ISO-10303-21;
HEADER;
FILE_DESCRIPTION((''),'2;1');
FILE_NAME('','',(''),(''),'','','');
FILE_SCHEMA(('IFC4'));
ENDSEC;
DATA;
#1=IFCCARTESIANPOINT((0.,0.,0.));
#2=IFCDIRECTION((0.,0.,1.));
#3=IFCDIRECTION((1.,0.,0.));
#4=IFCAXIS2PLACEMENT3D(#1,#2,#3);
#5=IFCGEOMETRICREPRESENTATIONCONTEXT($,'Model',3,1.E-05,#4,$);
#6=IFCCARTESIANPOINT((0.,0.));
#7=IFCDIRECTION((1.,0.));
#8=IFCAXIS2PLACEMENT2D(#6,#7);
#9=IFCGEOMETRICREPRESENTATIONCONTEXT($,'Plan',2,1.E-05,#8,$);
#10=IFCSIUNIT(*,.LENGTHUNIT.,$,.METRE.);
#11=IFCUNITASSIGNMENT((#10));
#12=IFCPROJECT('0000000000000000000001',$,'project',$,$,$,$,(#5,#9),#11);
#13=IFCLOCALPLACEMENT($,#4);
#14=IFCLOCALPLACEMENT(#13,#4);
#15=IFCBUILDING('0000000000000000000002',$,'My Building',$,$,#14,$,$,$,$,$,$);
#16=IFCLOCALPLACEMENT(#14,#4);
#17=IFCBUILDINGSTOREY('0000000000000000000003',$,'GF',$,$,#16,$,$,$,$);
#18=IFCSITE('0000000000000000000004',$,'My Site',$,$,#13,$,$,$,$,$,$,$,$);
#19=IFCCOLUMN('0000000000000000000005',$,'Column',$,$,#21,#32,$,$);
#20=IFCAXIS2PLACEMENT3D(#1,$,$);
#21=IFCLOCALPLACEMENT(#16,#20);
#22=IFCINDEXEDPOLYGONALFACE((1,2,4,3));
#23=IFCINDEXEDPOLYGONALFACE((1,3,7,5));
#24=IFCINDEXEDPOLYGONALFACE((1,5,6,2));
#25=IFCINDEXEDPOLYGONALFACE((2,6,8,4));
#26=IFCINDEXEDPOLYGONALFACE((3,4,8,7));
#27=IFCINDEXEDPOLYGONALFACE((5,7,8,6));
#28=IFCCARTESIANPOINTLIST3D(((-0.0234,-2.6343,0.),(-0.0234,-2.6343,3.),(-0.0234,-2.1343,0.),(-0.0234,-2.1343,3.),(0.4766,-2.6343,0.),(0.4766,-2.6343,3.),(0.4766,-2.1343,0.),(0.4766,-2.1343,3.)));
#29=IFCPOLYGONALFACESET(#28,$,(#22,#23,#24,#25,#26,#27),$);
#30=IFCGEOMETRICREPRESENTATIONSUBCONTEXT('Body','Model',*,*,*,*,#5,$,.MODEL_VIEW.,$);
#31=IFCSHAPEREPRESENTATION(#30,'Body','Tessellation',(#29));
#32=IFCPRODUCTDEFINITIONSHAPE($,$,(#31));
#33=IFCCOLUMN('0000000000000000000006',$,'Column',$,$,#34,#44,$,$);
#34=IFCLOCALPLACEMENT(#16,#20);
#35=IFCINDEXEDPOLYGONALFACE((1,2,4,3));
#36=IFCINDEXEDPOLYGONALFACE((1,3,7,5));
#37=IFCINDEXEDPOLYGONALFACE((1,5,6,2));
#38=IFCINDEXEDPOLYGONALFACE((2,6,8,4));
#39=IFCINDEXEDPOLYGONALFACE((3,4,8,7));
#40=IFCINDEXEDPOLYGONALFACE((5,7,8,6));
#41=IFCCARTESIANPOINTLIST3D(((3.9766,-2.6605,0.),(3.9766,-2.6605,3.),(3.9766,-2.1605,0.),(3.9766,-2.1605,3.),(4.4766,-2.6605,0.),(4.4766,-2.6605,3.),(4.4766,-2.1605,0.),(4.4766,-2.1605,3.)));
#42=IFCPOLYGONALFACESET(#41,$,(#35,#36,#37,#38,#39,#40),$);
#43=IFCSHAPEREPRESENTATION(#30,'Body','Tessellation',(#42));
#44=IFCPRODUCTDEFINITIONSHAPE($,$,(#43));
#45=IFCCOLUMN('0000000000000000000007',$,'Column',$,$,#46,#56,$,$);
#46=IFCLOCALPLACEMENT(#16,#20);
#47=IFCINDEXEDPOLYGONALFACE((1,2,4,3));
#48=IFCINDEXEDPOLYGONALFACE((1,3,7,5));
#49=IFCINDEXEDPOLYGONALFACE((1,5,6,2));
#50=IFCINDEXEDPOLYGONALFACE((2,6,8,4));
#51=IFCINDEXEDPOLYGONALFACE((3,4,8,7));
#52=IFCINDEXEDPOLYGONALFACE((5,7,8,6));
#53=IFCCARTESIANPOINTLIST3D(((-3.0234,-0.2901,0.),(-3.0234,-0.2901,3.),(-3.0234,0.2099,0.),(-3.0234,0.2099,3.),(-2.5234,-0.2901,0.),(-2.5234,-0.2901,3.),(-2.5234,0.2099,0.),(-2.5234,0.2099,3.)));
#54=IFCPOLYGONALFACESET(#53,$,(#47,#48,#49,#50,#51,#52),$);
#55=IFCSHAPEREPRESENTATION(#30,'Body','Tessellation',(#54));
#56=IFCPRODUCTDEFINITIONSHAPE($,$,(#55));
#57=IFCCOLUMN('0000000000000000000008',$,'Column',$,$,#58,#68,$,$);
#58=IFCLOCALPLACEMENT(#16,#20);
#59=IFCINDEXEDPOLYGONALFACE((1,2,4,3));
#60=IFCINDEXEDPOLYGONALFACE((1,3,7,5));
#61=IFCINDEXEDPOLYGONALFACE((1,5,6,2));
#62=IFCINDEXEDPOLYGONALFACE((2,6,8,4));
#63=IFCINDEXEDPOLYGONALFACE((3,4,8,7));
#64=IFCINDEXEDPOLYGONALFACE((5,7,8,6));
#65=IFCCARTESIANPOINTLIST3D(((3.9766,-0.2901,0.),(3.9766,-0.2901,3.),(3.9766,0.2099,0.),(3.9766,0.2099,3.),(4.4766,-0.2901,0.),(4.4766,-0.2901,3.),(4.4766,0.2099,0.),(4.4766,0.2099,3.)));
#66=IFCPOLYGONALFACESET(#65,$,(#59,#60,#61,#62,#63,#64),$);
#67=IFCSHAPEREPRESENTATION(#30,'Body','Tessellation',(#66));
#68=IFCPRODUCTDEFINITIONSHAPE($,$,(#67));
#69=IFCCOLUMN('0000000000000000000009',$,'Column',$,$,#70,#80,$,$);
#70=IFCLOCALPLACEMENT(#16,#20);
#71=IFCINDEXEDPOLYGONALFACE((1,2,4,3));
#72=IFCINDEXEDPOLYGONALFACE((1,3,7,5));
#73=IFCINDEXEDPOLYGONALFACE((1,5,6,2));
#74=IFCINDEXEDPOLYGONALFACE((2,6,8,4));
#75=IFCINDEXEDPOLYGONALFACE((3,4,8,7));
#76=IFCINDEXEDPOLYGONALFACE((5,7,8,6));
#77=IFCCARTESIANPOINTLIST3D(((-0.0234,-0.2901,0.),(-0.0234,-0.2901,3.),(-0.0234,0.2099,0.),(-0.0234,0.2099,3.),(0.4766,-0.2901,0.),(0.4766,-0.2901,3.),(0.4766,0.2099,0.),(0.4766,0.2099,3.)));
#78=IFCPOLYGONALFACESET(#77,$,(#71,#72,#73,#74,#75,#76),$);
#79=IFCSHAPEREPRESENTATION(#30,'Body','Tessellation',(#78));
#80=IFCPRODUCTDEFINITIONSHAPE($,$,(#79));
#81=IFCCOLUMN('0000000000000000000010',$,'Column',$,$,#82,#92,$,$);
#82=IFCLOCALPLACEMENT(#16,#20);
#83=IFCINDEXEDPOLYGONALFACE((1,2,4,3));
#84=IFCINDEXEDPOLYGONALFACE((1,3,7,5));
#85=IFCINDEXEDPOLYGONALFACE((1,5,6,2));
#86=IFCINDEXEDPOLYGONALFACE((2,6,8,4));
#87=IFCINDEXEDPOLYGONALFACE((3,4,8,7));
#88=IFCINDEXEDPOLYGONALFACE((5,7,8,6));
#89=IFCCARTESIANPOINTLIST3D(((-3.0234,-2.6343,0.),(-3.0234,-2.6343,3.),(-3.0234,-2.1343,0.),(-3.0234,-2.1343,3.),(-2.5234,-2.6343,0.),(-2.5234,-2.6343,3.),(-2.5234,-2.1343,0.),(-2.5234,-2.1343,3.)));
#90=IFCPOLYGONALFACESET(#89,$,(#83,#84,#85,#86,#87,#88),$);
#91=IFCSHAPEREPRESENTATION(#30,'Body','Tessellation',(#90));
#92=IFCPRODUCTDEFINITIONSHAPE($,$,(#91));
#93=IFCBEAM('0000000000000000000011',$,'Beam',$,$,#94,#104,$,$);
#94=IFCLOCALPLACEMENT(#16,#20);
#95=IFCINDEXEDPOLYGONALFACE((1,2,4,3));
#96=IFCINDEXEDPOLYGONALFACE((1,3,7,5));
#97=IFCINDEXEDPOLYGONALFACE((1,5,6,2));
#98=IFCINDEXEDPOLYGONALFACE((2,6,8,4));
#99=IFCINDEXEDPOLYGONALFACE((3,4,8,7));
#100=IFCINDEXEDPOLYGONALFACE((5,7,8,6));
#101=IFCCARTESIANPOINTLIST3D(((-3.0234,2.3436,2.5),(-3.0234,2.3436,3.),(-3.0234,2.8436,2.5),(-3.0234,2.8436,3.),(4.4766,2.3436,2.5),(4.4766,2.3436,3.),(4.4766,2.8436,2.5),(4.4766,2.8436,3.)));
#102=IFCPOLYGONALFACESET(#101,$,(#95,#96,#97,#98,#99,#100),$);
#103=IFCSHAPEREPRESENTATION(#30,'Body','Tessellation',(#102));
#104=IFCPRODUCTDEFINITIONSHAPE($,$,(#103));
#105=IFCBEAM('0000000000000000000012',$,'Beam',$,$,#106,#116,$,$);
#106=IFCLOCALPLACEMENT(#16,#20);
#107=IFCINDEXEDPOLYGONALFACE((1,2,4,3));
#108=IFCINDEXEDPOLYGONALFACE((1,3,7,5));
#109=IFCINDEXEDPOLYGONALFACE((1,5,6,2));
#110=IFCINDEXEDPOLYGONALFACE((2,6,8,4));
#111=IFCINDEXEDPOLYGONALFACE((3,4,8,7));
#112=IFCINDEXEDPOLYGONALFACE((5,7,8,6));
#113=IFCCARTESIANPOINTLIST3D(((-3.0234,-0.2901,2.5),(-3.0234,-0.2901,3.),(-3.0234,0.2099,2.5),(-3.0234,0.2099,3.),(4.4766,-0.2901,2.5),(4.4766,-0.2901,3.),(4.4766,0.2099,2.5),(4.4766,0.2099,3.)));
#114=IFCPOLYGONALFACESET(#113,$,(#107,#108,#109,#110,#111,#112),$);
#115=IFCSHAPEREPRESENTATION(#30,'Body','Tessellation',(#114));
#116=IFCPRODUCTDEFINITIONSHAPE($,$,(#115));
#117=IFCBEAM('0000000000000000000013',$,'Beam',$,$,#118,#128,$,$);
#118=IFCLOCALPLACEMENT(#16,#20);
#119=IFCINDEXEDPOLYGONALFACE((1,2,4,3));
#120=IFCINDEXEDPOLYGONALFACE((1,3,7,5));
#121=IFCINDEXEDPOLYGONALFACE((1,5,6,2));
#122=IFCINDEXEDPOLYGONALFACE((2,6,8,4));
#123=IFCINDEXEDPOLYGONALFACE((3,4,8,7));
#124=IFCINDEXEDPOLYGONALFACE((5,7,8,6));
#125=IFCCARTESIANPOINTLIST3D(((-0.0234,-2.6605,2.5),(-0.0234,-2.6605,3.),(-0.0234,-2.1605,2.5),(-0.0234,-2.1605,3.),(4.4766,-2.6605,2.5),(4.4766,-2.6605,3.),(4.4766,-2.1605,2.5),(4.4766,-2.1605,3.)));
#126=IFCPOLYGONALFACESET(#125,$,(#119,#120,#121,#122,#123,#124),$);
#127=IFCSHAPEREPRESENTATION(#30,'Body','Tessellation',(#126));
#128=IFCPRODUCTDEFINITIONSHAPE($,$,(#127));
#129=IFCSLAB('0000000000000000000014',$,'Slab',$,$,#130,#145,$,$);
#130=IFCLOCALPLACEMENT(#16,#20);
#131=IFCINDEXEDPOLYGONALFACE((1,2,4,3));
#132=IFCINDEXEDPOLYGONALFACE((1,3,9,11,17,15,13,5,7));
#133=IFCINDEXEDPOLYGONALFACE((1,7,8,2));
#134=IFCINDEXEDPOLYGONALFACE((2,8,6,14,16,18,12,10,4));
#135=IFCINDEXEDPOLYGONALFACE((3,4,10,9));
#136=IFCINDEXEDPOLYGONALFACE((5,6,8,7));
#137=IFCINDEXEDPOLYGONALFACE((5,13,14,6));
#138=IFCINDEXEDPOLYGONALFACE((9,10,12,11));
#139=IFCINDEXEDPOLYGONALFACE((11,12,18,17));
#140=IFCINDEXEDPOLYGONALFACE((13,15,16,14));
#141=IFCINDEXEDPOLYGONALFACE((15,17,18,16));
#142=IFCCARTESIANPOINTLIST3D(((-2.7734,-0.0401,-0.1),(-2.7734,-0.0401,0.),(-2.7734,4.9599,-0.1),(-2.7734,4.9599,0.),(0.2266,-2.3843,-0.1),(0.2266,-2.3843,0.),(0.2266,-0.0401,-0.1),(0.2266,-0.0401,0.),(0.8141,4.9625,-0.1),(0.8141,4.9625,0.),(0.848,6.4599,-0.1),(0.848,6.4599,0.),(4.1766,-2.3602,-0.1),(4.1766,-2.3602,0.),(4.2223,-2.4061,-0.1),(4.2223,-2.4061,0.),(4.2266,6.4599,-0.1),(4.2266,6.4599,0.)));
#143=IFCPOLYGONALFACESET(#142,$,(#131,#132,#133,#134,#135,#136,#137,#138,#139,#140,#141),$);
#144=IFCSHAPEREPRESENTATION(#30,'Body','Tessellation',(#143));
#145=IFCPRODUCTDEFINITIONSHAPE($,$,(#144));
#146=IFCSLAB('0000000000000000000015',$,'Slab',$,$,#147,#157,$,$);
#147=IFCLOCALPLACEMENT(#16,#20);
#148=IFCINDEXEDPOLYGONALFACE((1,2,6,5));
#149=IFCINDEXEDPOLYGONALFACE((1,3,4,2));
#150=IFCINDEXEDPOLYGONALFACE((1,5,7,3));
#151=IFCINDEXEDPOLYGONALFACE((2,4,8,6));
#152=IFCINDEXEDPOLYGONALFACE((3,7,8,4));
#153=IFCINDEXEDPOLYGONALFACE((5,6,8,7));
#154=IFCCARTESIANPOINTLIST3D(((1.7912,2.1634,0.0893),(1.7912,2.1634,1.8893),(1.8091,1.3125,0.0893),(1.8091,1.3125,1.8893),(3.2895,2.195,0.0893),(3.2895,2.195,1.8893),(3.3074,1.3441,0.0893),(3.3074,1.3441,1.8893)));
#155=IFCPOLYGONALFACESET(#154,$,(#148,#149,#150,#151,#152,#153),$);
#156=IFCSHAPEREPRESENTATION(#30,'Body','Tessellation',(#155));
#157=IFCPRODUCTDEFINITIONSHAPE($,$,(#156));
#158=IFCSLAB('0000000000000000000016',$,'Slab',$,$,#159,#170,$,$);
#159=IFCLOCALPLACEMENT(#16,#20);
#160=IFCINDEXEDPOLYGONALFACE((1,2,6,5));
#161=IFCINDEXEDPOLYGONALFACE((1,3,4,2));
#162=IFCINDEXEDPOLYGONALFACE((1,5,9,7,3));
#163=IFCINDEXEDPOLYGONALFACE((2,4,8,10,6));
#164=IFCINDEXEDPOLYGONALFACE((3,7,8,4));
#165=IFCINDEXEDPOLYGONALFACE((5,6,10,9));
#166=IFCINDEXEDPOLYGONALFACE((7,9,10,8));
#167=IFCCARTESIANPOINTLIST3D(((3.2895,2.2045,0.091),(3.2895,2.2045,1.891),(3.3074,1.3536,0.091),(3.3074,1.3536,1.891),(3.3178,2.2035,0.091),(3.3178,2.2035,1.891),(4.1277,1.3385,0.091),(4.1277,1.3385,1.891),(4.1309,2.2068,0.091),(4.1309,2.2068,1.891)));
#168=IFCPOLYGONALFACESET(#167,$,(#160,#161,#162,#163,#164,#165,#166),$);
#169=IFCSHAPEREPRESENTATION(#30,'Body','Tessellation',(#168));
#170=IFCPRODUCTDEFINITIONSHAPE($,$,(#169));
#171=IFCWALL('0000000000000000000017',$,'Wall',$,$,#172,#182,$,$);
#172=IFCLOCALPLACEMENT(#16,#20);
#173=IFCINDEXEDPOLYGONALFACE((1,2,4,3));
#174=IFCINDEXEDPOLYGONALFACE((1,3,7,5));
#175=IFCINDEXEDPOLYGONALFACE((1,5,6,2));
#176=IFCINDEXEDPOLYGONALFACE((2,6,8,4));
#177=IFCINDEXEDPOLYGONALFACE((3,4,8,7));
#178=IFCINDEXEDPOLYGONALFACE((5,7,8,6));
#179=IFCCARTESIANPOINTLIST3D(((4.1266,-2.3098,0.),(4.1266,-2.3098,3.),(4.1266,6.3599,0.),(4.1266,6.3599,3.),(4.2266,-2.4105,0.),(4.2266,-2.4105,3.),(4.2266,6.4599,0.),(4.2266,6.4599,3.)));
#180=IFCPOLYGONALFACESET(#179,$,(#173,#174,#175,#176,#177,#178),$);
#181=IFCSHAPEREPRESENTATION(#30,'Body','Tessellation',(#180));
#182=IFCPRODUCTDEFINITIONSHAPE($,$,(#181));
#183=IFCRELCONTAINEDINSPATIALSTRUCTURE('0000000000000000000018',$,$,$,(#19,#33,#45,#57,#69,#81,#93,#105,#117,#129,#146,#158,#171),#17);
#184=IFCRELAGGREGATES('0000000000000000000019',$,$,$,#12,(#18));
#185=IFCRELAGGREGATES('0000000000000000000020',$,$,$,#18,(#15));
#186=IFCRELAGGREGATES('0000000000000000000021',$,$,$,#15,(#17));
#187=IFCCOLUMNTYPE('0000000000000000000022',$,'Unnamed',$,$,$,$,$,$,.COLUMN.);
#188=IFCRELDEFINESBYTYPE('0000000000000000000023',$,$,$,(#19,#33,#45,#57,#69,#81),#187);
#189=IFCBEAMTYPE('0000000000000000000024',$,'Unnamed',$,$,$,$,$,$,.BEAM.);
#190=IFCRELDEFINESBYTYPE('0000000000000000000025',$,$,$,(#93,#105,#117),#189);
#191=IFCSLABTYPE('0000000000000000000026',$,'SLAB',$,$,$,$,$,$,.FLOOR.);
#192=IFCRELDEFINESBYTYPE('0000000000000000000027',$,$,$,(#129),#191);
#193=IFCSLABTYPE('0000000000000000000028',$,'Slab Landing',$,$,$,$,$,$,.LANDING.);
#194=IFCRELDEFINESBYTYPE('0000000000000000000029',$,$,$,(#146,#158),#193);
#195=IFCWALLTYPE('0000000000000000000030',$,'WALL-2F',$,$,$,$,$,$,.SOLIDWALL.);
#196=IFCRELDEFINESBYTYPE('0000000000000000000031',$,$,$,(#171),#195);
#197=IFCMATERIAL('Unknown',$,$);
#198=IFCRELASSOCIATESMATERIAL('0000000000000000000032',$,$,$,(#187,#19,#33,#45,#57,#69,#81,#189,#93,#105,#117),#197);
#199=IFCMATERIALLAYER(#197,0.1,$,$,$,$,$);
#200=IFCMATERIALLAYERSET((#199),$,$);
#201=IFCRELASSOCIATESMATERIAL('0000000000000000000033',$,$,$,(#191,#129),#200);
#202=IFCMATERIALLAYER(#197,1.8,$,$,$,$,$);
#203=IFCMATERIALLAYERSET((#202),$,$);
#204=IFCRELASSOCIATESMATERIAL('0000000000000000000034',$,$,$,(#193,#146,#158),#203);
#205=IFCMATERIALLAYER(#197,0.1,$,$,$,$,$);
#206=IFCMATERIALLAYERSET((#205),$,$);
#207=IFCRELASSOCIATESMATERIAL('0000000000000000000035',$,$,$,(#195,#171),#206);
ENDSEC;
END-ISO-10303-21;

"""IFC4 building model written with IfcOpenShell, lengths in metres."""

from ifc_helpers import new_model, si_unit, frame, origin_with_axes, origin_2d_with_axis, place, context, subcontext, project, spatial, line, indexed_curve, rectangle, outline, extrude, material, layer, layer_set, layer_usage, material_profile, profile_set, profile_usage, type_object, element, save


model = new_model("IFC4")

# Units and contexts
model_context = context("Model", 3, precision=1e-05, world=origin_with_axes())
plan_context = context("Plan", 2, precision=1e-05, world=origin_2d_with_axis())
body_context_1 = subcontext(model_context, "Body", "Model", "MODEL_VIEW")
ifc_project = project(units=[si_unit("LENGTHUNIT", "METRE")], contexts=[model_context, plan_context])

# Site, building, storey
site_placement = place(None, origin_with_axes())
site = spatial("IfcSite", under=ifc_project, at=site_placement, Name="My Site")
building_placement = place(site_placement, origin_with_axes())
building = spatial("IfcBuilding", under=site, at=building_placement, Name="My Building")
storey_placement = place(building_placement, origin_with_axes())
storey = spatial("IfcBuildingStorey", under=building, at=storey_placement, Name="GF")

# Columns
ifc_material = material(Name="Unknown")
ifc_material_profile_1 = material_profile(ifc_material, rectangle(XDim=0.5, YDim=0.5))
ifc_profile_set_1 = profile_set([ifc_material_profile_1])
ifc_profile_usage_1 = profile_usage(ifc_profile_set_1, cardinal=5)
column_type = type_object("IfcColumnType", Name="Unnamed", PredefinedType="COLUMN", material=ifc_profile_set_1)
column_1_placement = place(storey_placement, frame((0.2266, -2.3843, 0.0), z_axis=(0.0, 0.0, 1.0), x_axis=(1.0, 0.0, 0.0)))
element("IfcColumn", 1, at=column_1_placement, inside=storey, type_object=column_type, material=ifc_profile_usage_1, Name="Column", context=body_context_1, shape_type="SweptSolid", body=[
    extrude(rectangle(XDim=0.5, YDim=0.5), origin_with_axes(), (0.0, 0.0, 1.0), 3.0),
])
ifc_profile_usage_2 = profile_usage(ifc_profile_set_1, cardinal=5)
column_2_placement = place(storey_placement, frame((4.2266, -2.4105, 0.0), z_axis=(0.0, 0.0, 1.0), x_axis=(1.0, 0.0, 0.0)))
element("IfcColumn", 2, at=column_2_placement, inside=storey, type_object=column_type, material=ifc_profile_usage_2, Name="Column", context=body_context_1, shape_type="SweptSolid", body=[
    extrude(rectangle(XDim=0.5, YDim=0.5), origin_with_axes(), (0.0, 0.0, 1.0), 3.0),
])
ifc_profile_usage_3 = profile_usage(ifc_profile_set_1, cardinal=5)
column_3_placement = place(storey_placement, frame((-2.7734, -0.0401, 0.0), z_axis=(0.0, 0.0, 1.0), x_axis=(1.0, 0.0, 0.0)))
element("IfcColumn", 3, at=column_3_placement, inside=storey, type_object=column_type, material=ifc_profile_usage_3, Name="Column", context=body_context_1, shape_type="SweptSolid", body=[
    extrude(rectangle(XDim=0.5, YDim=0.5), origin_with_axes(), (0.0, 0.0, 1.0), 3.0),
])
ifc_profile_usage_4 = profile_usage(ifc_profile_set_1, cardinal=5)
column_4_placement = place(storey_placement, frame((4.2266, -0.0401, 0.0), z_axis=(0.0, 0.0, 1.0), x_axis=(1.0, 0.0, 0.0)))
element("IfcColumn", 4, at=column_4_placement, inside=storey, type_object=column_type, material=ifc_profile_usage_4, Name="Column", context=body_context_1, shape_type="SweptSolid", body=[
    extrude(rectangle(XDim=0.5, YDim=0.5), origin_with_axes(), (0.0, 0.0, 1.0), 3.0),
])
ifc_profile_usage_5 = profile_usage(ifc_profile_set_1, cardinal=5)
column_5_placement = place(storey_placement, frame((0.2266, -0.0401, 0.0), z_axis=(0.0, 0.0, 1.0), x_axis=(1.0, 0.0, 0.0)))
element("IfcColumn", 5, at=column_5_placement, inside=storey, type_object=column_type, material=ifc_profile_usage_5, Name="Column", context=body_context_1, shape_type="SweptSolid", body=[
    extrude(rectangle(XDim=0.5, YDim=0.5), origin_with_axes(), (0.0, 0.0, 1.0), 3.0),
])
ifc_profile_usage_6 = profile_usage(ifc_profile_set_1, cardinal=5)
column_6_placement = place(storey_placement, frame((-2.7734, -2.3843, 0.0), z_axis=(0.0, 0.0, 1.0), x_axis=(1.0, 0.0, 0.0)))
element("IfcColumn", 6, at=column_6_placement, inside=storey, type_object=column_type, material=ifc_profile_usage_6, Name="Column", context=body_context_1, shape_type="SweptSolid", body=[
    extrude(rectangle(XDim=0.5, YDim=0.5), origin_with_axes(), (0.0, 0.0, 1.0), 3.0),
])

# Beams
ifc_material_profile_2 = material_profile(ifc_material, rectangle(XDim=0.5, YDim=0.5))
ifc_profile_set_2 = profile_set([ifc_material_profile_2])
ifc_profile_usage_7 = profile_usage(ifc_profile_set_2, cardinal=7)
beam_type = type_object("IfcBeamType", Name="Unnamed", PredefinedType="BEAM", material=ifc_profile_set_2)
beam_1_placement = place(storey_placement, frame((4.4766, 2.3436, 3.0), z_axis=(-1.0, 0.0, 0.0), x_axis=(0.0, -1.0, 0.0)))
element("IfcBeam", 7, at=beam_1_placement, inside=storey, type_object=beam_type, material=ifc_profile_usage_7, Name="Beam", context=body_context_1, shape_type="SweptSolid", body=[
    extrude(rectangle(XDim=0.5, YDim=0.5), frame((-0.25, -0.25, 0.0), z_axis=(0.0, 0.0, 1.0), x_axis=(1.0, 0.0, 0.0)), (0.0, 0.0, 1.0), 7.5),
])
ifc_profile_usage_8 = profile_usage(ifc_profile_set_2, cardinal=7)
beam_2_placement = place(storey_placement, frame((4.4766, -0.2901, 3.0), z_axis=(-1.0, 0.0, 0.0), x_axis=(0.0, -1.0, 0.0)))
element("IfcBeam", 8, at=beam_2_placement, inside=storey, type_object=beam_type, material=ifc_profile_usage_8, Name="Beam", context=body_context_1, shape_type="SweptSolid", body=[
    extrude(rectangle(XDim=0.5, YDim=0.5), frame((-0.25, -0.25, 0.0), z_axis=(0.0, 0.0, 1.0), x_axis=(1.0, 0.0, 0.0)), (0.0, 0.0, 1.0), 7.5),
])
ifc_profile_usage_9 = profile_usage(ifc_profile_set_2, cardinal=7)
beam_3_placement = place(storey_placement, frame((-0.0234, -2.1605, 3.0), z_axis=(1.0, 0.0, 0.0), x_axis=(0.0, 1.0, 0.0)))
element("IfcBeam", 9, at=beam_3_placement, inside=storey, type_object=beam_type, material=ifc_profile_usage_9, Name="Beam", context=body_context_1, shape_type="SweptSolid", body=[
    extrude(rectangle(XDim=0.5, YDim=0.5), frame((-0.25, -0.25, 0.0), z_axis=(0.0, 0.0, 1.0), x_axis=(1.0, 0.0, 0.0)), (0.0, 0.0, 1.0), 4.5),
])

# Slabs
ifc_layer_1 = layer(ifc_material, 0.1)
ifc_layer_set_1 = layer_set([ifc_layer_1])
ifc_layer_usage_1 = layer_usage(ifc_layer_set_1, "AXIS3", "POSITIVE", -0.1)
slab_type_1 = type_object("IfcSlabType", Name="SLAB", PredefinedType="FLOOR", material=ifc_layer_set_1)
slab_1_placement = place(storey_placement, frame((4.2223, -2.4061, 0.0), z_axis=(0.0, 0.0, 1.0), x_axis=(1.0, 0.0, 0.0)))
element("IfcSlab", 10, at=slab_1_placement, inside=storey, type_object=slab_type_1, material=ifc_layer_usage_1, Name="Slab", context=body_context_1, shape_type="SweptSolid", body=[
    extrude(outline(indexed_curve([(0.0, 0.0), (0.0043, 8.866), (-3.3742, 8.866), (-3.4082, 7.3687), (-6.9957, 7.366), (-6.9957, 2.366), (-3.9957, 2.366), (-3.9957, 0.0219), (-0.0457, 0.046), (0.0, 0.0)])), frame((0.0, 0.0, -0.1), z_axis=(0.0, 0.0, 1.0), x_axis=(1.0, 0.0, 0.0)), (0.0, 0.0, 1.0), 0.1),
])
ifc_layer_2 = layer(ifc_material, 1.8)
ifc_layer_set_2 = layer_set([ifc_layer_2])
slab_type_2 = type_object("IfcSlabType", Name="Slab Landing", PredefinedType="LANDING", material=ifc_layer_set_2)
ifc_layer_usage_2 = layer_usage(ifc_layer_set_2, "AXIS3", "POSITIVE", -1.8)
slab_2_placement = place(storey_placement, frame((3.2895, 2.195, 1.8893), z_axis=(0.0, 0.0, 1.0), x_axis=(1.0, 0.0, 0.0)))
element("IfcSlab", 11, at=slab_2_placement, inside=storey, type_object=slab_type_2, material=ifc_layer_usage_2, Name="Slab", context=body_context_1, shape_type="SweptSolid", body=[
    extrude(outline(indexed_curve([(0.0, 0.0), (0.0179, -0.8509), (-1.4804, -0.8824), (-1.4983, -0.0315), (0.0, 0.0)])), frame((0.0, 0.0, -1.8), z_axis=(0.0, 0.0, 1.0), x_axis=(1.0, 0.0, 0.0)), (0.0, 0.0, 1.0), 1.8),
])
ifc_layer_usage_3 = layer_usage(ifc_layer_set_2, "AXIS3", "POSITIVE", -1.8)
slab_3_placement = place(storey_placement, frame((3.3178, 2.2035, 1.891), z_axis=(0.0, 0.0, 1.0), x_axis=(1.0, 0.0, 0.0)))
element("IfcSlab", 12, at=slab_3_placement, inside=storey, type_object=slab_type_2, material=ifc_layer_usage_3, Name="Slab", context=body_context_1, shape_type="SweptSolid", body=[
    extrude(outline(indexed_curve([(0.0, 0.0), (0.8131, 0.0032), (0.8098, -0.865), (-0.0104, -0.8499), (-0.0284, 0.001), (0.0, 0.0)])), frame((0.0, 0.0, -1.8), z_axis=(0.0, 0.0, 1.0), x_axis=(1.0, 0.0, 0.0)), (0.0, 0.0, 1.0), 1.8),
])

# Wall
ifc_layer_3 = layer(ifc_material, 0.1)
ifc_layer_set_3 = layer_set([ifc_layer_3])
ifc_layer_usage_4 = layer_usage(ifc_layer_set_3, "AXIS2", "POSITIVE", 0.0)
wall_type_1 = type_object("IfcWallType", Name="WALL-2F", PredefinedType="SOLIDWALL", material=ifc_layer_set_3)
wall_1_placement = place(storey_placement, frame((4.2266, -2.4105, 0.0), z_axis=(0.0, 0.0, 1.0), x_axis=(0.0, 1.0, 0.0)))
element("IfcWall", 13, at=wall_1_placement, inside=storey, type_object=wall_type_1, material=ifc_layer_usage_4, Name="Wall", context=body_context_1, shape_type="SweptSolid", body=[
    extrude(outline(indexed_curve([(0.0, 0.0), (0.1007, 0.1), (8.7704, 0.1), (8.8704, 0.0)], segments=[line(1, 2, 3, 4, 1)])), origin_with_axes(), (0.0, 0.0, 1.0), 3.0),
])

save(model, "model.ifc")
